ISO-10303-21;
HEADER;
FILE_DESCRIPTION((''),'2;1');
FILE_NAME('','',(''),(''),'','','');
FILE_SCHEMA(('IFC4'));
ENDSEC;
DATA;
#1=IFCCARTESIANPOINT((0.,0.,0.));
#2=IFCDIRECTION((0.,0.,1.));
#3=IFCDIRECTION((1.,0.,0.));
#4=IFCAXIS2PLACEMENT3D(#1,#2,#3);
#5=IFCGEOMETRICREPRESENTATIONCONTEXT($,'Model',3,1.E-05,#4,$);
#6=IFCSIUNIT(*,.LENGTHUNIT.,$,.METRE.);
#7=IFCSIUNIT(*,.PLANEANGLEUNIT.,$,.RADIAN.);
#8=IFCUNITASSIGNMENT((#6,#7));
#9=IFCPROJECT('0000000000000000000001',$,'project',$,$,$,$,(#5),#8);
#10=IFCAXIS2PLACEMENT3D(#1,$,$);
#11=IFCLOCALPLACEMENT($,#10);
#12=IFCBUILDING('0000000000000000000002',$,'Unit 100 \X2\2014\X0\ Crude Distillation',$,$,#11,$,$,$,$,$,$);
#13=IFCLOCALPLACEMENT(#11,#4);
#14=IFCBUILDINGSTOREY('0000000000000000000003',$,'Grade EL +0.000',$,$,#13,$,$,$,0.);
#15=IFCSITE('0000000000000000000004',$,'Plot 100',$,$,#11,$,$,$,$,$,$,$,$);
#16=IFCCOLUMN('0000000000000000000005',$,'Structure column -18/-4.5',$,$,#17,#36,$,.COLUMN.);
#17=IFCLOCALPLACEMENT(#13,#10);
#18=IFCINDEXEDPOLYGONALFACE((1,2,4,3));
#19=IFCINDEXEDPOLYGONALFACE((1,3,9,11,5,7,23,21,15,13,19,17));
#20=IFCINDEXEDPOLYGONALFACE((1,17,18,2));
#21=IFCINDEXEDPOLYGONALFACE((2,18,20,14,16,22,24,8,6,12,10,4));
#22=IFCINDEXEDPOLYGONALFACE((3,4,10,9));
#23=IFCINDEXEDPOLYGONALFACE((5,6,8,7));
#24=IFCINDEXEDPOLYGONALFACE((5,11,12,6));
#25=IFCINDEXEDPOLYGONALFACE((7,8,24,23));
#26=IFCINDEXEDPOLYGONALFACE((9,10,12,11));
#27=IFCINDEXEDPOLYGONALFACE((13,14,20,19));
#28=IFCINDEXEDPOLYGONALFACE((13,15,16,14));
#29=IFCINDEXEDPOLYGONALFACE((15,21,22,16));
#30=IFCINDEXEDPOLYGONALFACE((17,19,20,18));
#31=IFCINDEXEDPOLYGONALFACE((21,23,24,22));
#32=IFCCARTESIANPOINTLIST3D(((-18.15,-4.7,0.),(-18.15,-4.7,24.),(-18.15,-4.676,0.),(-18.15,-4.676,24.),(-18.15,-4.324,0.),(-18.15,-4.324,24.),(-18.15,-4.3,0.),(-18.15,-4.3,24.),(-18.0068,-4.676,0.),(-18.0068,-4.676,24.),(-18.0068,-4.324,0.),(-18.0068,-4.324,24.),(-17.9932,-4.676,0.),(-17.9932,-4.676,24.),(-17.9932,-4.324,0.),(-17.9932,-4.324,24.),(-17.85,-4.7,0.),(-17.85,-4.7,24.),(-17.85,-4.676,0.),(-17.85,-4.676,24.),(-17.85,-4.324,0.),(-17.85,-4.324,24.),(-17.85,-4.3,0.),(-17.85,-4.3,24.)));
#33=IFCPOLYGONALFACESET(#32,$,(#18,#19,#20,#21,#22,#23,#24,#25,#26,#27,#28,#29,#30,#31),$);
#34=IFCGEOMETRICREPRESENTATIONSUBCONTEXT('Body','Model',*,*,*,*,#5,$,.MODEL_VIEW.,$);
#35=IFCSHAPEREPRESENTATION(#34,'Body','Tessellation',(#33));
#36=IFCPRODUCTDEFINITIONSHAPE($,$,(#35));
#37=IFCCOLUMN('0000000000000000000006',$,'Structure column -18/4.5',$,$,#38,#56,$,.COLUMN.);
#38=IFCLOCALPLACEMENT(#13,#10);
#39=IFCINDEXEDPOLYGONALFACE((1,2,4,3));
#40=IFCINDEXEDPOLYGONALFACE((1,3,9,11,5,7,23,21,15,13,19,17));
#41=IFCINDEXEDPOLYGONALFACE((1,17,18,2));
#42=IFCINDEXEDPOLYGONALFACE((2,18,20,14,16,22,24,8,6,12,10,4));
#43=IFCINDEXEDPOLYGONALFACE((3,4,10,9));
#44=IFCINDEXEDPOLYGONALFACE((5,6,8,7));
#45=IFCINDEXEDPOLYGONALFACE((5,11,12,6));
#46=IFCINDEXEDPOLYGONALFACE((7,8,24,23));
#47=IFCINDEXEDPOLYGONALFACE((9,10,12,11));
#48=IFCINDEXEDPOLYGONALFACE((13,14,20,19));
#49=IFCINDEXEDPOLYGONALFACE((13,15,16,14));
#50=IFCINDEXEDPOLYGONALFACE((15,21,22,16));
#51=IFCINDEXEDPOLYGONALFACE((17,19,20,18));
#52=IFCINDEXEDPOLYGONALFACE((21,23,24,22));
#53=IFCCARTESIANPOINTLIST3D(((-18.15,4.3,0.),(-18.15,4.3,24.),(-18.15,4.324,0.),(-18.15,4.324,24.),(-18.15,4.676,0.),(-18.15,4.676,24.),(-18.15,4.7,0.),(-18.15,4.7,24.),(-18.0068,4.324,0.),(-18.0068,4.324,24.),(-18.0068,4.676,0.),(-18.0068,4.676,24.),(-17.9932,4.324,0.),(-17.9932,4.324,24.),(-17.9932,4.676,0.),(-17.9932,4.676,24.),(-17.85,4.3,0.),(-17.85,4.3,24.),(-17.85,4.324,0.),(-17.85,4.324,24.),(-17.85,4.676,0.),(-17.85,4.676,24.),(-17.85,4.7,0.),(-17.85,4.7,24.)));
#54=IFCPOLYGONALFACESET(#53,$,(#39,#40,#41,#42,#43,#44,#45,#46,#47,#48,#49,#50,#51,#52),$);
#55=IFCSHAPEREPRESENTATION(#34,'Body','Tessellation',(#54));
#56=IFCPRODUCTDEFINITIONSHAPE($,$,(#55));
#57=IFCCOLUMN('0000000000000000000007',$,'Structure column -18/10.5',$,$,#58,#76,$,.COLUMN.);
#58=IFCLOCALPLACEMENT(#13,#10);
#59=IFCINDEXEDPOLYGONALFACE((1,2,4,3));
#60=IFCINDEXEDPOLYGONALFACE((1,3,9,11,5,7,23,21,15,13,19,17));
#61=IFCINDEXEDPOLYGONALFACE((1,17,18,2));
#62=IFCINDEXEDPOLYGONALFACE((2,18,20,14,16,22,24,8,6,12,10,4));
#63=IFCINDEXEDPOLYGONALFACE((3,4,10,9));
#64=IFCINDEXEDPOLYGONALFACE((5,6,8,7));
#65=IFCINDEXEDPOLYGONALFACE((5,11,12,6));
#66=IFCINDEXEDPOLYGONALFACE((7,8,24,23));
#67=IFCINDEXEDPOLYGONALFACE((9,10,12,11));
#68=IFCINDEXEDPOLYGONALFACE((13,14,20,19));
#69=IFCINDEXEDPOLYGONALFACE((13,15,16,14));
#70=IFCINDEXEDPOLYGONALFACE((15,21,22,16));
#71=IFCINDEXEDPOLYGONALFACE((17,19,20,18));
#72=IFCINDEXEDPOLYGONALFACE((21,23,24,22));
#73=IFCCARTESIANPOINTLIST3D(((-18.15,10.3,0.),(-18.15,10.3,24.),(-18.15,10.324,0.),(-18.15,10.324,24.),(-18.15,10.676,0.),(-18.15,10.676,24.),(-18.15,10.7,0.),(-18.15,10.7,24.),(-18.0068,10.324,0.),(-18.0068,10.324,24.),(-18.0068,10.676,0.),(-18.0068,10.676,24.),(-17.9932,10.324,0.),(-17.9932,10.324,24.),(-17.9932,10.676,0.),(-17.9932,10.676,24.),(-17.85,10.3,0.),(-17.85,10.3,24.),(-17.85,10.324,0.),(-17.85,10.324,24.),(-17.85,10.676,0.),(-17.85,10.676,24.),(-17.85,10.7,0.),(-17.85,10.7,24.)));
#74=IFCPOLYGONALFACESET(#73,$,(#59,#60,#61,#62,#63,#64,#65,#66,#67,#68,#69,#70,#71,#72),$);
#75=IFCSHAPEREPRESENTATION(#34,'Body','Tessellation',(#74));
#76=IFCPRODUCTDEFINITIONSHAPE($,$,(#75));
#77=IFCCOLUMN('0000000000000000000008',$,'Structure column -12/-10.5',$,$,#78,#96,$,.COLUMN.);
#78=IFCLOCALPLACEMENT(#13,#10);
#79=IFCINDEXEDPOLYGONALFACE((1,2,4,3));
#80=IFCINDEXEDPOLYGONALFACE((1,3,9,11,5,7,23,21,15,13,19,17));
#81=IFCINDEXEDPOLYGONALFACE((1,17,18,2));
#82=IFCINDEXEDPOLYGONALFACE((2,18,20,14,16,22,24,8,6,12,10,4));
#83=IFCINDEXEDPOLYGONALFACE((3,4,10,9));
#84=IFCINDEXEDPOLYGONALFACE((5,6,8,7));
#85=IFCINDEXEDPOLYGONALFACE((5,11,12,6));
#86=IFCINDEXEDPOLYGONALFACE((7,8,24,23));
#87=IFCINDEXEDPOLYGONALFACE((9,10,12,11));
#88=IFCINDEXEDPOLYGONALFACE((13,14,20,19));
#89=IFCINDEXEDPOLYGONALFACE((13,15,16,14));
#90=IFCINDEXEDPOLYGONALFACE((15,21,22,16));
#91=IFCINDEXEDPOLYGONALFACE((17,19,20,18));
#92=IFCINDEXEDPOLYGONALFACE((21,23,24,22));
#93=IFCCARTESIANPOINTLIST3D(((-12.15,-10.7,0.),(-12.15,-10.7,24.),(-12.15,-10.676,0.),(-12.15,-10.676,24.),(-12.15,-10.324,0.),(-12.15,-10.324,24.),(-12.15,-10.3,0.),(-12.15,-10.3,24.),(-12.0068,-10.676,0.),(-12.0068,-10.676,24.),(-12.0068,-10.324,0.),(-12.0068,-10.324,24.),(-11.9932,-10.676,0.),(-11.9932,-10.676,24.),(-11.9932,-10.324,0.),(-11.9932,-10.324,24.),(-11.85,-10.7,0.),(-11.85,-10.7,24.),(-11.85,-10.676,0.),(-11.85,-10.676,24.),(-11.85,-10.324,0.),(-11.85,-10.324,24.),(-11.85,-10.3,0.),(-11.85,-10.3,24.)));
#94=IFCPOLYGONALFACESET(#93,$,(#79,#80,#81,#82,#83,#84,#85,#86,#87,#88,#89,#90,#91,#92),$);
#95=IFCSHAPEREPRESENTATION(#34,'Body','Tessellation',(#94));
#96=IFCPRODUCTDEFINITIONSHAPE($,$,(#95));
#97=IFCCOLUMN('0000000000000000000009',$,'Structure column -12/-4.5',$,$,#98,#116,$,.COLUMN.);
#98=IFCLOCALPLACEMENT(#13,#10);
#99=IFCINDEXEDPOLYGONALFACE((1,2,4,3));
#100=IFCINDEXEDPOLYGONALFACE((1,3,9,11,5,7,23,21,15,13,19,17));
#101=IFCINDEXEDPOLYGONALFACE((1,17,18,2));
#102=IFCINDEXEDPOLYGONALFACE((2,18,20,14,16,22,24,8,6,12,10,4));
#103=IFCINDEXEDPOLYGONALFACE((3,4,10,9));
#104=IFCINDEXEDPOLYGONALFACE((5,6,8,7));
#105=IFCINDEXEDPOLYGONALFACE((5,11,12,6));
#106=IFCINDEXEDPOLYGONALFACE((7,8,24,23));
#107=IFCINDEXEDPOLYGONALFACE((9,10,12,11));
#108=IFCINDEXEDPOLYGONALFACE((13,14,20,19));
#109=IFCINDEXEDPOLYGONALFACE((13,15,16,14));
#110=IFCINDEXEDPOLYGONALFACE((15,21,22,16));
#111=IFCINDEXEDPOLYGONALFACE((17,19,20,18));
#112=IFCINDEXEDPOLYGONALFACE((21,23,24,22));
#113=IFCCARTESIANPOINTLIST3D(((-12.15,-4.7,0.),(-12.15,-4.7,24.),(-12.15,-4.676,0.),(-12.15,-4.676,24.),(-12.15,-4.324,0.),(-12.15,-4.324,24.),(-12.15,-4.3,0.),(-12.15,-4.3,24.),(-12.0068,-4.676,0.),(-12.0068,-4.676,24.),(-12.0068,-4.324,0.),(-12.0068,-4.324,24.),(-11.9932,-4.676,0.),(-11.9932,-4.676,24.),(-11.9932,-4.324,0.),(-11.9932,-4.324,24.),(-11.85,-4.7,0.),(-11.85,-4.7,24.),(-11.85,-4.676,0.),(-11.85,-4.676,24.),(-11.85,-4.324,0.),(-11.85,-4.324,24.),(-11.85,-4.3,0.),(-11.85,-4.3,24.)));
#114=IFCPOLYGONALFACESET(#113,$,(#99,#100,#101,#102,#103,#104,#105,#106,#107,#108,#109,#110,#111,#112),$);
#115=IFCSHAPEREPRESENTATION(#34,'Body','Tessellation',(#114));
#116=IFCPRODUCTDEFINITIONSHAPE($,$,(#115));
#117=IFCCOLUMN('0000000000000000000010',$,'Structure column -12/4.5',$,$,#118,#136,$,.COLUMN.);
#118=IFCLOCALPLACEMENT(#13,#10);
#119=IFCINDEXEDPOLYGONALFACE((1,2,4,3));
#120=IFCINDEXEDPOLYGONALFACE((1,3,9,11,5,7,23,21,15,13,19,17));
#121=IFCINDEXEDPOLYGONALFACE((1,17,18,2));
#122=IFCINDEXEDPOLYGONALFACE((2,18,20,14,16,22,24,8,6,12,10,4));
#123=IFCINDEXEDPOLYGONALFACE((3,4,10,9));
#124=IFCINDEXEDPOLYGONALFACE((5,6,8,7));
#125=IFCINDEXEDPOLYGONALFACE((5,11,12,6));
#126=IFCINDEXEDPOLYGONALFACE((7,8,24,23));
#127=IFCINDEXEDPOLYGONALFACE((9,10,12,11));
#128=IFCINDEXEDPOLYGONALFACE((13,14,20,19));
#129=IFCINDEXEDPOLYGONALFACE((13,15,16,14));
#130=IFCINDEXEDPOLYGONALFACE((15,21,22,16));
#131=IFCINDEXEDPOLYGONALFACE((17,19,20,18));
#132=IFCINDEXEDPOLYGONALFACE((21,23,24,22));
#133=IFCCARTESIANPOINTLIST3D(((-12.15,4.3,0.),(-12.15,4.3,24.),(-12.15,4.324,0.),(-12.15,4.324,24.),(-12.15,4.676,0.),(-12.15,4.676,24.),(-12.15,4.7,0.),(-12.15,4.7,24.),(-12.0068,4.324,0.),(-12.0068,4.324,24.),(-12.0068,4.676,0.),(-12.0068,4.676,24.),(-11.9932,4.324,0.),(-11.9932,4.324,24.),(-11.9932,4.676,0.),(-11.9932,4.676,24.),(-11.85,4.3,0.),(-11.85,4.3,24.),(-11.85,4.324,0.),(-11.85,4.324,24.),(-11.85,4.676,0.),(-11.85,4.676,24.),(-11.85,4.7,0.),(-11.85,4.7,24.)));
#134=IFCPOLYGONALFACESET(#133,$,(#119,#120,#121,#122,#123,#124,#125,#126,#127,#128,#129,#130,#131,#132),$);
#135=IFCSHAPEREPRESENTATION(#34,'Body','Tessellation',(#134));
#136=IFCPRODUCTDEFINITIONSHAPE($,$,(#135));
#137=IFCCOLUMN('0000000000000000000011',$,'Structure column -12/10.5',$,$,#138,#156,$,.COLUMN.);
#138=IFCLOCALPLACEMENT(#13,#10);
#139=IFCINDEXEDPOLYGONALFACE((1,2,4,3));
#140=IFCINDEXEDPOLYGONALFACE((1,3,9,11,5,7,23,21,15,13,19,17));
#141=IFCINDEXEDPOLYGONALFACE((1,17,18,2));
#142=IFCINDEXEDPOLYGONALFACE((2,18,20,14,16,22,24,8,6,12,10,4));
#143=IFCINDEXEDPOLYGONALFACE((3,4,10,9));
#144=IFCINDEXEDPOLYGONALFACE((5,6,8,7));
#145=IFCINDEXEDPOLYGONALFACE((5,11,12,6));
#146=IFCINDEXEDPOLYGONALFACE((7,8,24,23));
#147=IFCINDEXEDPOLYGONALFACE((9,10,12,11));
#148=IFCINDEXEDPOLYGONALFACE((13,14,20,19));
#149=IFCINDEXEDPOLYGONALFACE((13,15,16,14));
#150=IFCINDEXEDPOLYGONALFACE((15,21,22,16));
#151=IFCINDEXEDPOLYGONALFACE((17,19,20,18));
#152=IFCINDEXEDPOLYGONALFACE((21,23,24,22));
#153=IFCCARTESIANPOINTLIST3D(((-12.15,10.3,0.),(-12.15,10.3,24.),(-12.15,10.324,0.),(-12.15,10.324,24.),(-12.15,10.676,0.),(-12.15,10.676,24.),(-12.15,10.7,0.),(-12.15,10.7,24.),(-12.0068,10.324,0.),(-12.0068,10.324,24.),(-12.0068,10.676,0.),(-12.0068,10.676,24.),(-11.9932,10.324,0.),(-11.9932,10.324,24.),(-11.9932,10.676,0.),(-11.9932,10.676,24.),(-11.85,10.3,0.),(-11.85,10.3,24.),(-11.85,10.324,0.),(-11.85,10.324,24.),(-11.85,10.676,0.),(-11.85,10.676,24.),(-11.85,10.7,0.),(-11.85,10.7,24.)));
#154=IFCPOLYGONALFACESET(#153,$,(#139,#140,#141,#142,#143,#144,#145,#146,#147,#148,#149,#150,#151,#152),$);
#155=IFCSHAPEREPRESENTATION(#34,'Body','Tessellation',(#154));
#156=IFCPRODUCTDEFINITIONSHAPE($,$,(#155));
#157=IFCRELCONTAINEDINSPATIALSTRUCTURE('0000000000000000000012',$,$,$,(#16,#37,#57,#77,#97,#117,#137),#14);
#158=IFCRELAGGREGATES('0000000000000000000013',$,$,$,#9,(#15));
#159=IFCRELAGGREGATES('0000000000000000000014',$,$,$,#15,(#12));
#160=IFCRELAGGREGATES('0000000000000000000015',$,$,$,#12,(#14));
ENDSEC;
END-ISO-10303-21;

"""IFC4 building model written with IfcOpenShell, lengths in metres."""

from ifc_helpers import new_model, si_unit, frame, origin, origin_with_axes, origin_2d, place, context, subcontext, project, spatial, i_section, extrude, element, save


model = new_model("IFC4")

# Units and contexts
model_context = context("Model", 3, precision=1e-05, world=origin_with_axes())
body_context = subcontext(model_context, "Body", "Model", "MODEL_VIEW")
ifc_project = project(units=[si_unit("LENGTHUNIT", "METRE"), si_unit("PLANEANGLEUNIT", "RADIAN")], contexts=[model_context])

# Site, building, storey
placement = place(None, origin())
site = spatial("IfcSite", under=ifc_project, at=placement, Name="Plot 100")
building = spatial("IfcBuilding", under=site, at=placement, Name="Unit 100 — Crude Distillation")
storey_placement = place(placement, origin_with_axes())
storey = spatial("IfcBuildingStorey", under=building, at=storey_placement, Name="Grade EL +0.000", Elevation=0.0)

# Columns
column_1_placement = place(storey_placement, origin_with_axes())
element("IfcColumn", 1, at=column_1_placement, inside=storey, Name="Structure column -18/-4.5", PredefinedType="COLUMN", context=body_context, shape_type="SweptSolid", body=[
    extrude(i_section(OverallWidth=0.3, OverallDepth=0.4, WebThickness=0.0135, FlangeThickness=0.024, at=origin_2d()), frame((-18.0, -4.5, 0.0), z_axis=(0.0, 0.0, 1.0), x_axis=(1.0, 0.0, 0.0)), (0.0, 0.0, 1.0), 24.0),
])
column_2_placement = place(storey_placement, origin_with_axes())
element("IfcColumn", 2, at=column_2_placement, inside=storey, Name="Structure column -18/4.5", PredefinedType="COLUMN", context=body_context, shape_type="SweptSolid", body=[
    extrude(i_section(OverallWidth=0.3, OverallDepth=0.4, WebThickness=0.0135, FlangeThickness=0.024, at=origin_2d()), frame((-18.0, 4.5, 0.0), z_axis=(0.0, 0.0, 1.0), x_axis=(1.0, 0.0, 0.0)), (0.0, 0.0, 1.0), 24.0),
])
column_3_placement = place(storey_placement, origin_with_axes())
element("IfcColumn", 3, at=column_3_placement, inside=storey, Name="Structure column -18/10.5", PredefinedType="COLUMN", context=body_context, shape_type="SweptSolid", body=[
    extrude(i_section(OverallWidth=0.3, OverallDepth=0.4, WebThickness=0.0135, FlangeThickness=0.024, at=origin_2d()), frame((-18.0, 10.5, 0.0), z_axis=(0.0, 0.0, 1.0), x_axis=(1.0, 0.0, 0.0)), (0.0, 0.0, 1.0), 24.0),
])
column_4_placement = place(storey_placement, origin_with_axes())
element("IfcColumn", 4, at=column_4_placement, inside=storey, Name="Structure column -12/-10.5", PredefinedType="COLUMN", context=body_context, shape_type="SweptSolid", body=[
    extrude(i_section(OverallWidth=0.3, OverallDepth=0.4, WebThickness=0.0135, FlangeThickness=0.024, at=origin_2d()), frame((-12.0, -10.5, 0.0), z_axis=(0.0, 0.0, 1.0), x_axis=(1.0, 0.0, 0.0)), (0.0, 0.0, 1.0), 24.0),
])
column_5_placement = place(storey_placement, origin_with_axes())
element("IfcColumn", 5, at=column_5_placement, inside=storey, Name="Structure column -12/-4.5", PredefinedType="COLUMN", context=body_context, shape_type="SweptSolid", body=[
    extrude(i_section(OverallWidth=0.3, OverallDepth=0.4, WebThickness=0.0135, FlangeThickness=0.024, at=origin_2d()), frame((-12.0, -4.5, 0.0), z_axis=(0.0, 0.0, 1.0), x_axis=(1.0, 0.0, 0.0)), (0.0, 0.0, 1.0), 24.0),
])
column_6_placement = place(storey_placement, origin_with_axes())
element("IfcColumn", 6, at=column_6_placement, inside=storey, Name="Structure column -12/4.5", PredefinedType="COLUMN", context=body_context, shape_type="SweptSolid", body=[
    extrude(i_section(OverallWidth=0.3, OverallDepth=0.4, WebThickness=0.0135, FlangeThickness=0.024, at=origin_2d()), frame((-12.0, 4.5, 0.0), z_axis=(0.0, 0.0, 1.0), x_axis=(1.0, 0.0, 0.0)), (0.0, 0.0, 1.0), 24.0),
])
column_7_placement = place(storey_placement, origin_with_axes())
element("IfcColumn", 7, at=column_7_placement, inside=storey, Name="Structure column -12/10.5", PredefinedType="COLUMN", context=body_context, shape_type="SweptSolid", body=[
    extrude(i_section(OverallWidth=0.3, OverallDepth=0.4, WebThickness=0.0135, FlangeThickness=0.024, at=origin_2d()), frame((-12.0, 10.5, 0.0), z_axis=(0.0, 0.0, 1.0), x_axis=(1.0, 0.0, 0.0)), (0.0, 0.0, 1.0), 24.0),
])

save(model, "model.ifc")
